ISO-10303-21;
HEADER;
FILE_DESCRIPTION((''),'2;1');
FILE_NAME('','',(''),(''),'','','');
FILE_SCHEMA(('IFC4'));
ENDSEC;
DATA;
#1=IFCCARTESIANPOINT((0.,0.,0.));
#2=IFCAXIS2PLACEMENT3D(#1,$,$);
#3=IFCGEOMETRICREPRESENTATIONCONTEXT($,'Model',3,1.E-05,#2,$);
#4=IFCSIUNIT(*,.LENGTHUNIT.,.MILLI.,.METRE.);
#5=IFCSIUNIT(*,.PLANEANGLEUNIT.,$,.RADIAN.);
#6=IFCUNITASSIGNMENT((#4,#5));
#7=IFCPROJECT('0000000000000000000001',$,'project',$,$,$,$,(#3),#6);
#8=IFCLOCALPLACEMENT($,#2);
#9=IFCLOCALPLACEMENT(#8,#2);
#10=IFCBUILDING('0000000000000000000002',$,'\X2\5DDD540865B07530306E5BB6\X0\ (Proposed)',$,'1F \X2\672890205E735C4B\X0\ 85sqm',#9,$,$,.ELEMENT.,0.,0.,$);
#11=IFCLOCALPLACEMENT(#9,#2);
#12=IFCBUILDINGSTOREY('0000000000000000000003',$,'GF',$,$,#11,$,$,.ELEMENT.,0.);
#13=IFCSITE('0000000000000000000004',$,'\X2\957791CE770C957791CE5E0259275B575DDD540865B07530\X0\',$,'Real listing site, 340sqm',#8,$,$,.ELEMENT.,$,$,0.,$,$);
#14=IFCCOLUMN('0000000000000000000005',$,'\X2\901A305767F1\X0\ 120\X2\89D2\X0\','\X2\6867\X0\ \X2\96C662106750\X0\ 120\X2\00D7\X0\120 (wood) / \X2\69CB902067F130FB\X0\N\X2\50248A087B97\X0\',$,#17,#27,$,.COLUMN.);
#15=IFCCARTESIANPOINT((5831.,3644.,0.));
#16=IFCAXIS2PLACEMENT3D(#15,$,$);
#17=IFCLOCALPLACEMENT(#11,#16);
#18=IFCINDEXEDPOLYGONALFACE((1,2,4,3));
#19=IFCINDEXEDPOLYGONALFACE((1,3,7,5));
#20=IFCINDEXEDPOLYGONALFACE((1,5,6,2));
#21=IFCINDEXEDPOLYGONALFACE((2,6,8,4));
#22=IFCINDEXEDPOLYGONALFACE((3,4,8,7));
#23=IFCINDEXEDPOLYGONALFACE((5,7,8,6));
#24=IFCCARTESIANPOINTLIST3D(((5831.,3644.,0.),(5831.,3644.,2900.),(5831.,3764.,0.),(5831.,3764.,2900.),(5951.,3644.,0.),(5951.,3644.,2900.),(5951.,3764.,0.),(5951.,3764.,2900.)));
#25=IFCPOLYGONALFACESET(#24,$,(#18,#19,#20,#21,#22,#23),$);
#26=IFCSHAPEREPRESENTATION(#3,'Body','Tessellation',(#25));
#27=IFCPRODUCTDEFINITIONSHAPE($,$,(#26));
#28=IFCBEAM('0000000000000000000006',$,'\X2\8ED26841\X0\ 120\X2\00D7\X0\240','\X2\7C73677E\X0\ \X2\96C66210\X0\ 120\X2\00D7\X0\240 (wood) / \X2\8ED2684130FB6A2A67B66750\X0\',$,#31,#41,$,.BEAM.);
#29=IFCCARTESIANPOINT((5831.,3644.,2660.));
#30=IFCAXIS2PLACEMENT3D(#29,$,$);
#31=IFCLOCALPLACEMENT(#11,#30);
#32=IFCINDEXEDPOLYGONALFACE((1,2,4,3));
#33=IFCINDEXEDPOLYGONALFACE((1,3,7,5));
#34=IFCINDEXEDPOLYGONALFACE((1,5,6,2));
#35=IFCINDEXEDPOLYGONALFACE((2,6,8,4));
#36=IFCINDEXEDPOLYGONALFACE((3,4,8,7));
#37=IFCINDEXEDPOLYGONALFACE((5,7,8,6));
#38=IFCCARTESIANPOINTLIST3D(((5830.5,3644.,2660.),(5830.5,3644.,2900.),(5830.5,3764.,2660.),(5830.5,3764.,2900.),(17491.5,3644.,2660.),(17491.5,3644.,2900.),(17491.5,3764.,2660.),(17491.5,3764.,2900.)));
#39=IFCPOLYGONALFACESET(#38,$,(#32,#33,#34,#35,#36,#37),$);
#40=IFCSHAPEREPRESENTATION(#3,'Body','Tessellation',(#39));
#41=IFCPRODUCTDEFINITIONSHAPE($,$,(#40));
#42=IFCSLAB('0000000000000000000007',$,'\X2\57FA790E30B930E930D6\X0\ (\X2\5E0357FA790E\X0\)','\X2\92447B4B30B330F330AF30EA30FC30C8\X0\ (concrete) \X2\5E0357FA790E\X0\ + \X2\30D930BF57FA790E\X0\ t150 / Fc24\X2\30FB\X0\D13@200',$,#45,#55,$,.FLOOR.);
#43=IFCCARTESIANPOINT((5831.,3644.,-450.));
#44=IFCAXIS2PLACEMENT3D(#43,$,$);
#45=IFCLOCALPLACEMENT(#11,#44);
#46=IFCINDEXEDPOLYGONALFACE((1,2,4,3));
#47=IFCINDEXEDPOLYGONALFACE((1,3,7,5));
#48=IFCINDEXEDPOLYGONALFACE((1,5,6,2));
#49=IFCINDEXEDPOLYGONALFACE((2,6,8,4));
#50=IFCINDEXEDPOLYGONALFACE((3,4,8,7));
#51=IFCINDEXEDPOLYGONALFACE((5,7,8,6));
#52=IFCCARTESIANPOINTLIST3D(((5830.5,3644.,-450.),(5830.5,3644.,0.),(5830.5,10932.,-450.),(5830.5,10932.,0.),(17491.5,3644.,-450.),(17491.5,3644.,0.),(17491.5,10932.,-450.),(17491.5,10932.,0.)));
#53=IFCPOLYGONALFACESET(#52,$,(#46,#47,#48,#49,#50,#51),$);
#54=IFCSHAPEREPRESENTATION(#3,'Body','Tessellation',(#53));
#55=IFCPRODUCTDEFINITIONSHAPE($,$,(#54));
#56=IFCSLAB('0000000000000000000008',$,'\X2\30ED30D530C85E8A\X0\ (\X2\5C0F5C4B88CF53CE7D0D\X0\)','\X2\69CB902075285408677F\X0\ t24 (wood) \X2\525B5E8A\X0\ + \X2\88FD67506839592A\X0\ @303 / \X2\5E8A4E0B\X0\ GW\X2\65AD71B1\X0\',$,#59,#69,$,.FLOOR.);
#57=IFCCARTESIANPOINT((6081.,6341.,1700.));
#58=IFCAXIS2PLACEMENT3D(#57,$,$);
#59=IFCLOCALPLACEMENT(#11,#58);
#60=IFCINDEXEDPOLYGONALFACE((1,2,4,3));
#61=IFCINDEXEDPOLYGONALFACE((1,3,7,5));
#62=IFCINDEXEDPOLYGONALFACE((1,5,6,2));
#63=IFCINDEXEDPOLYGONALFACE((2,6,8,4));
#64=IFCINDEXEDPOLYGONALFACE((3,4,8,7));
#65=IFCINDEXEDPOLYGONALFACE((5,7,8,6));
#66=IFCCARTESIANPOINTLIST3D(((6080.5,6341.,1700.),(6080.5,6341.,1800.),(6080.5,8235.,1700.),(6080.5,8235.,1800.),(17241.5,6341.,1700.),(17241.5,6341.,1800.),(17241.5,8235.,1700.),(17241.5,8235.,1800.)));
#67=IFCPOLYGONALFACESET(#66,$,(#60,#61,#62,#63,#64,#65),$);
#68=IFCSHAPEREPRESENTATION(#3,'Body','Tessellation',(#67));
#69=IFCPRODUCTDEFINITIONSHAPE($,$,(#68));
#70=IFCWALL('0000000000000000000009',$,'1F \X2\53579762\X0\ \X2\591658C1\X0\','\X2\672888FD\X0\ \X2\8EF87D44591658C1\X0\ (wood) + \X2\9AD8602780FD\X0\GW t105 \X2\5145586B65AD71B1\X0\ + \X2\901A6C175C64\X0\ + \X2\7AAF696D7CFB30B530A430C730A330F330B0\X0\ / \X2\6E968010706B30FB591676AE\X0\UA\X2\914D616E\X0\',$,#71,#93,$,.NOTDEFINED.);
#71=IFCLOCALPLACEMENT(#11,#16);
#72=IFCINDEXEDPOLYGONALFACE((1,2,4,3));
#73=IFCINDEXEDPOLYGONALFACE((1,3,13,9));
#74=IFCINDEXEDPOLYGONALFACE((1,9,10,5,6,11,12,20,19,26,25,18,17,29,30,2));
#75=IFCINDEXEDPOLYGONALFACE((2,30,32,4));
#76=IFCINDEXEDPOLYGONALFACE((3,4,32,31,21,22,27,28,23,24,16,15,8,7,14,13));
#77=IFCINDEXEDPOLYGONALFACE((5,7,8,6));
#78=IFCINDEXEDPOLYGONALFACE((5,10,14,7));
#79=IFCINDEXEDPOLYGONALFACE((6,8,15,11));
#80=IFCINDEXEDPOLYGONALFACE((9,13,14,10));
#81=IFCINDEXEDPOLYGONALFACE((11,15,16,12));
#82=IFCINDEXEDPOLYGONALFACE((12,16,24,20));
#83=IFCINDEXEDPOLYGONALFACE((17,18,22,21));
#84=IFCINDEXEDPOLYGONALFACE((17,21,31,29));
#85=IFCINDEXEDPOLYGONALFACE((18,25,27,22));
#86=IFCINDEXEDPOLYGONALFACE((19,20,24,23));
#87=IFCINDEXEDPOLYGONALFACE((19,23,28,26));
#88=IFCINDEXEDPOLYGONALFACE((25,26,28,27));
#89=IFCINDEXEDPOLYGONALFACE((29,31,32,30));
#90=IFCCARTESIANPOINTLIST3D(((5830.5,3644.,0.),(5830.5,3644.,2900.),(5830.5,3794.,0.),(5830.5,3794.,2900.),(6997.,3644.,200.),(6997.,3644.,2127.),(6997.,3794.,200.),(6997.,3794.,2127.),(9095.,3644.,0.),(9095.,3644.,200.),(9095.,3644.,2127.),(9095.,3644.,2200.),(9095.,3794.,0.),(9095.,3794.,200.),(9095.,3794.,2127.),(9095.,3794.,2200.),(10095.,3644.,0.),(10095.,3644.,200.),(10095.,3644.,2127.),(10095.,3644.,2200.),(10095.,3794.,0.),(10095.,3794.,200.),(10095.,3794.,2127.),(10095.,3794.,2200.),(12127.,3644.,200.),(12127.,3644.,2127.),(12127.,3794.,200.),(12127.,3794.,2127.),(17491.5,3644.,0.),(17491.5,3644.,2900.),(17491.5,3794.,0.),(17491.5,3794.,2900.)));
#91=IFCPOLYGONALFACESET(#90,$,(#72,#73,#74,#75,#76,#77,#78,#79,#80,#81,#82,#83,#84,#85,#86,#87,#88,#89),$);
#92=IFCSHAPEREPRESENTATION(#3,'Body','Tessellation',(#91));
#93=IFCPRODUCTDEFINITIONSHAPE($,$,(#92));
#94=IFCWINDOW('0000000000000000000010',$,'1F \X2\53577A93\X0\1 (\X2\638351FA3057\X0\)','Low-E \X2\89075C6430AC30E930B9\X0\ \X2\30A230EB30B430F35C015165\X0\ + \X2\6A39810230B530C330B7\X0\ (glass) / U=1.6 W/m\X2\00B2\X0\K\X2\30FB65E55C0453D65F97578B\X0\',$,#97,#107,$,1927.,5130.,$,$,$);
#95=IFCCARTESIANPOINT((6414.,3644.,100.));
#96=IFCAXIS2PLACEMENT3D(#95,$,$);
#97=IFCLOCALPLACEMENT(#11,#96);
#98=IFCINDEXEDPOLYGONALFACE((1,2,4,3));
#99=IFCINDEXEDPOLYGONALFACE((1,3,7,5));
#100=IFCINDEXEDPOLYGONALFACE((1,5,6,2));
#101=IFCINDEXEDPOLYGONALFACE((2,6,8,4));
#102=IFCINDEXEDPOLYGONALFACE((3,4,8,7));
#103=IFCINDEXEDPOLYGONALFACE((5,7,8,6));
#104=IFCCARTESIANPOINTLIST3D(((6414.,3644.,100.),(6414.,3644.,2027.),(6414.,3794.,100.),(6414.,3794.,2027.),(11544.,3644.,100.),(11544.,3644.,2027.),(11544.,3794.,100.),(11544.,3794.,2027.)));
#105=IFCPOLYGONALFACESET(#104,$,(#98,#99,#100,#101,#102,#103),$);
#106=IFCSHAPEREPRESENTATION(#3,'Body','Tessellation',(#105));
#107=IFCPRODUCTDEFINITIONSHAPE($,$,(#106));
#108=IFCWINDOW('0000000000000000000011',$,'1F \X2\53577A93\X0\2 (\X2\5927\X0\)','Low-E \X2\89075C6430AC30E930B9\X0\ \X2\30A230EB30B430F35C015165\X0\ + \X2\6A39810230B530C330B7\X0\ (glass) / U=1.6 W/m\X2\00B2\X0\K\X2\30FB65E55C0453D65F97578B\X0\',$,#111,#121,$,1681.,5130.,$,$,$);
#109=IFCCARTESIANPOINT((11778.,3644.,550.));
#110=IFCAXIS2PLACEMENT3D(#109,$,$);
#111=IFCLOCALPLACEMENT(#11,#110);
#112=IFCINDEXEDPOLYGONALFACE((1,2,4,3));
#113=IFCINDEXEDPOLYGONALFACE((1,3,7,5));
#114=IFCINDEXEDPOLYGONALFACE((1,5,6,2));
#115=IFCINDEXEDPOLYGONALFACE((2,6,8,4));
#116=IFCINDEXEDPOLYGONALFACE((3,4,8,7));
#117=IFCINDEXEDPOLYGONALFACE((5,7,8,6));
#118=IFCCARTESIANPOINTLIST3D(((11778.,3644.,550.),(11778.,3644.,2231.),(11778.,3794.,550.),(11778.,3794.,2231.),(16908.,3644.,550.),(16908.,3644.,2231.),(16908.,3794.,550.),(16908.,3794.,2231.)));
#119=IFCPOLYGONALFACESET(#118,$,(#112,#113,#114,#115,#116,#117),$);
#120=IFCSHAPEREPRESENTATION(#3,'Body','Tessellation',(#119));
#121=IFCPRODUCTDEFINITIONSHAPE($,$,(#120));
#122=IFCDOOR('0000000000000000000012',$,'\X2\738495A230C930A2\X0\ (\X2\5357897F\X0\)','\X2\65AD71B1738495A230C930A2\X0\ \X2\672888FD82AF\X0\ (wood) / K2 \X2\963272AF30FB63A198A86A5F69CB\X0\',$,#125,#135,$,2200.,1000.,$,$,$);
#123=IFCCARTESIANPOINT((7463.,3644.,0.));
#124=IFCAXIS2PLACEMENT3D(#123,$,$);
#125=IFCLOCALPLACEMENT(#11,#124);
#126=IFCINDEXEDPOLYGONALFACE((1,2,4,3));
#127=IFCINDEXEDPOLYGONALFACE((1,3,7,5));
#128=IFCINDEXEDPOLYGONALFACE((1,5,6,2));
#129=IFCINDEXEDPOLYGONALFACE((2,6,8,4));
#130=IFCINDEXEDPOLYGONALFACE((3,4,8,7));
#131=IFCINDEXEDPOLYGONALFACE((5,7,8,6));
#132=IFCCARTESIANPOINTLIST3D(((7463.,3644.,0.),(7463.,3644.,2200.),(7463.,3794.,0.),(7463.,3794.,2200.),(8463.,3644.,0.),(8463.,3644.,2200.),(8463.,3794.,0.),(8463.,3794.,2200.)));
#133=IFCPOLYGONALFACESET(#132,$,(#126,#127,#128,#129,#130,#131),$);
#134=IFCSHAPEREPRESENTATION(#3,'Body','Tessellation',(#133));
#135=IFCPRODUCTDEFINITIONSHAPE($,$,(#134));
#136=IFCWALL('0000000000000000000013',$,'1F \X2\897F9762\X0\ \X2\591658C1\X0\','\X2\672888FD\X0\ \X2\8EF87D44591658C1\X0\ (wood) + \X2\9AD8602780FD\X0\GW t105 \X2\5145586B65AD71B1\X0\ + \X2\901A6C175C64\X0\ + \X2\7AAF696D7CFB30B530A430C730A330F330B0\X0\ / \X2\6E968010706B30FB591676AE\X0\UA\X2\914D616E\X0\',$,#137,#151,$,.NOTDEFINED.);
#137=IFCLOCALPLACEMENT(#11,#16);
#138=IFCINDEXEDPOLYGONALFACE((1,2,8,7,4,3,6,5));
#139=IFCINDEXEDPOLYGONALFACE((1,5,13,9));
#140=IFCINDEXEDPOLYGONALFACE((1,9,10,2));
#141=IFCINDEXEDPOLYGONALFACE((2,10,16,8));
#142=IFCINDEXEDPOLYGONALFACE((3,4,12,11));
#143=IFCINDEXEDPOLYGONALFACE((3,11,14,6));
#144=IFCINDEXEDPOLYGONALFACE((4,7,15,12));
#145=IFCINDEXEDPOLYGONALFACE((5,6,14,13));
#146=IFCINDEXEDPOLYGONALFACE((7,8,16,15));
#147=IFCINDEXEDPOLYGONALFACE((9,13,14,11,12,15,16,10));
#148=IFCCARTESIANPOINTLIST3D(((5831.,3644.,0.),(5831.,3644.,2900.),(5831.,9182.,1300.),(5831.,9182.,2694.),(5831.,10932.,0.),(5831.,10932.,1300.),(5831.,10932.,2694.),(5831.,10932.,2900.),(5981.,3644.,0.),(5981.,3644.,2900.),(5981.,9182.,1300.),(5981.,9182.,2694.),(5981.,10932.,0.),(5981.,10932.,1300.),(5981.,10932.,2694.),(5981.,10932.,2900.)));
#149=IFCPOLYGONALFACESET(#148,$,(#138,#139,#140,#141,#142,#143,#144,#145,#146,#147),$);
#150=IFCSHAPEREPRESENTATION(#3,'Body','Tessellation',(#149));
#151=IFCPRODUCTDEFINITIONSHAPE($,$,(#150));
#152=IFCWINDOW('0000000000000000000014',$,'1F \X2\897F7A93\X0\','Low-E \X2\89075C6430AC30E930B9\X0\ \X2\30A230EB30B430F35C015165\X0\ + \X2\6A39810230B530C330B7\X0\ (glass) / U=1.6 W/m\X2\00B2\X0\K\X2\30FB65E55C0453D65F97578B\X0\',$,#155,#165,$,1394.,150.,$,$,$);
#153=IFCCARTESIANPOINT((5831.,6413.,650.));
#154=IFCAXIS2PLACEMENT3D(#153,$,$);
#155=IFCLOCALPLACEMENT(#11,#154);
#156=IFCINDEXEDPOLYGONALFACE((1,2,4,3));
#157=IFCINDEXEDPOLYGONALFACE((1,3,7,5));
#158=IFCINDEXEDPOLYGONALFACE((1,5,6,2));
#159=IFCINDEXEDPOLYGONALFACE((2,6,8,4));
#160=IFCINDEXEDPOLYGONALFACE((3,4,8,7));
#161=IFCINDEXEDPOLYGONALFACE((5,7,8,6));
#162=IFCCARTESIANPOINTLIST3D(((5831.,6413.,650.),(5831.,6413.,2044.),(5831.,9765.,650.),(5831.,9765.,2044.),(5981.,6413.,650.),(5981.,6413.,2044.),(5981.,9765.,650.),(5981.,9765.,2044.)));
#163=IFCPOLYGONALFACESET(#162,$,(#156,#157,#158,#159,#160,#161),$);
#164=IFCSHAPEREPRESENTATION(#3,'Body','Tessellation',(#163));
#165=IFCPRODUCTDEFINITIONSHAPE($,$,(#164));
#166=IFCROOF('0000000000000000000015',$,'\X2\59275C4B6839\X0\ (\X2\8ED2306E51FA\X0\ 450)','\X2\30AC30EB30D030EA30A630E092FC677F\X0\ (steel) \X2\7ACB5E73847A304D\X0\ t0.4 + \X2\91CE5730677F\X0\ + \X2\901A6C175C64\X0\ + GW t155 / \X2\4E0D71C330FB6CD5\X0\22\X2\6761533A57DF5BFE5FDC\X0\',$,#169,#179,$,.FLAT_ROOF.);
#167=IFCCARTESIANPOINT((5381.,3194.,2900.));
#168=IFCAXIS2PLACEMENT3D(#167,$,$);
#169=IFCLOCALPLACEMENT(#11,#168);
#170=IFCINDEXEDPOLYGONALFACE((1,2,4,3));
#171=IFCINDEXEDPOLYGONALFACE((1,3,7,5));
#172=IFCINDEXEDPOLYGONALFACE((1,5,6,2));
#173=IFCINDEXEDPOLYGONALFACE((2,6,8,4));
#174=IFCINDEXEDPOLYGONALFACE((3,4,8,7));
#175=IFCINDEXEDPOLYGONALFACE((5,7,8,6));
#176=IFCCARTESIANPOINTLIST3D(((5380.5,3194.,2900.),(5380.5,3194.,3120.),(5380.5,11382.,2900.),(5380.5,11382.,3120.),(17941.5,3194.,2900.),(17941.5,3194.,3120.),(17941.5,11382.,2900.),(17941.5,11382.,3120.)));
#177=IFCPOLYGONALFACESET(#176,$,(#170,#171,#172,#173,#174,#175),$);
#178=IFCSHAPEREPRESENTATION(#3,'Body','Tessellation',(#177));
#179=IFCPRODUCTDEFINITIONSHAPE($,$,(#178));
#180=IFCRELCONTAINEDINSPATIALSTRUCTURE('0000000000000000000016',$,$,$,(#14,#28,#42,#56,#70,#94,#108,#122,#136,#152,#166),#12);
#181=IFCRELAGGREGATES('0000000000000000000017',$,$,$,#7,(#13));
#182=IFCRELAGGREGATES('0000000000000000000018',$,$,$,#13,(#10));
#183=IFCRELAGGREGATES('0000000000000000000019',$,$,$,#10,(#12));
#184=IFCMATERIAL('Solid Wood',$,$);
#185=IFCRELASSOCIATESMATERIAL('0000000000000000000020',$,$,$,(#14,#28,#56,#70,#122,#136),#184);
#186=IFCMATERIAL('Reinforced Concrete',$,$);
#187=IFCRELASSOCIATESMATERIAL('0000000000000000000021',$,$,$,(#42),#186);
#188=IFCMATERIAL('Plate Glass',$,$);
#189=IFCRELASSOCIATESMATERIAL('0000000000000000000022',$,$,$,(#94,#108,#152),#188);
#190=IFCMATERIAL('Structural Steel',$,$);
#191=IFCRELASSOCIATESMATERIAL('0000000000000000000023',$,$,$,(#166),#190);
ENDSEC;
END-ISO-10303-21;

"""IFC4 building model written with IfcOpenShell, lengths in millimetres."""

from ifc_helpers import new_model, si_unit, frame, frame_2d, origin, place, context, project, spatial, rectangle, extrude, material, element, fill, save


model = new_model("IFC4")

# Units and contexts
model_context = context("Model", 3, precision=1e-05, world=origin())
ifc_project = project(units=[si_unit("LENGTHUNIT", "METRE", prefix="MILLI"), si_unit("PLANEANGLEUNIT", "RADIAN")], contexts=[model_context])

# Site, building, storey
site_placement = place(None, origin())
site = spatial("IfcSite", under=ifc_project, at=site_placement, Name="長野県長野市大字川合新田", ObjectType="Real listing site, 340sqm", CompositionType="ELEMENT", RefElevation=0.0)
building_placement = place(site_placement, origin())
building = spatial("IfcBuilding", under=site, at=building_placement, Name="川合新田の家 (Proposed)", ObjectType="1F 木造平屋 85sqm", CompositionType="ELEMENT", ElevationOfRefHeight=0.0, ElevationOfTerrain=0.0)
storey_placement = place(building_placement, origin())
storey = spatial("IfcBuildingStorey", under=building, at=storey_placement, Name="GF", CompositionType="ELEMENT", Elevation=0.0)

# Column
ifc_material_1 = material(Name="Solid Wood")
column_1_placement = place(storey_placement, frame((5831.0, 3644.0, 0.0)))
element("IfcColumn", 1, at=column_1_placement, inside=storey, material=ifc_material_1, Name="通し柱 120角", Description="桧 集成材 120×120 (wood) / 構造柱・N値計算", PredefinedType="COLUMN", context=model_context, shape_type="SweptSolid", body=[
    extrude(rectangle(XDim=120.0, YDim=120.0, at=frame_2d((60.0, 60.0))), frame((5831.0, 3644.0, 0.0)), (0.0, 0.0, 1.0), 2900.0),
])

# Beam
beam_1_placement = place(storey_placement, frame((5831.0, 3644.0, 2660.0)))
element("IfcBeam", 2, at=beam_1_placement, inside=storey, material=ifc_material_1, Name="軒桁 120×240", Description="米松 集成 120×240 (wood) / 軒桁・横架材", PredefinedType="BEAM", context=model_context, shape_type="SweptSolid", body=[
    extrude(rectangle(XDim=11661.0, YDim=120.0, at=frame_2d((5830.0, 60.0))), frame((5831.0, 3644.0, 2660.0)), (0.0, 0.0, 1.0), 240.0),
])

# Slabs
ifc_material_2 = material(Name="Reinforced Concrete")
slab_1_placement = place(storey_placement, frame((5831.0, 3644.0, -450.0)))
element("IfcSlab", 3, at=slab_1_placement, inside=storey, material=ifc_material_2, Name="基礎スラブ (布基礎)", Description="鉄筋コンクリート (concrete) 布基礎 + ベタ基礎 t150 / Fc24・D13@200", PredefinedType="FLOOR", context=model_context, shape_type="SweptSolid", body=[
    extrude(rectangle(XDim=11661.0, YDim=7288.0, at=frame_2d((5830.0, 3644.0))), frame((5831.0, 3644.0, -450.0)), (0.0, 0.0, 1.0), 450.0),
])
slab_2_placement = place(storey_placement, frame((6081.0, 6341.0, 1700.0)))
element("IfcSlab", 4, at=slab_2_placement, inside=storey, material=ifc_material_1, Name="ロフト床 (小屋裏収納)", Description="構造用合板 t24 (wood) 剛床 + 製材根太 @303 / 床下 GW断熱", PredefinedType="FLOOR", context=model_context, shape_type="SweptSolid", body=[
    extrude(rectangle(XDim=11161.0, YDim=1894.0, at=frame_2d((5580.0, 947.0))), frame((6081.0, 6341.0, 1700.0)), (0.0, 0.0, 1.0), 100.0),
])

# Wall, openings, windows, door
wall_1_placement = place(storey_placement, frame((5831.0, 3644.0, 0.0)))
wall_1 = element("IfcWall", 5, at=wall_1_placement, inside=storey, material=ifc_material_1, Name="1F 南面 外壁", Description="木製 軸組外壁 (wood) + 高性能GW t105 充填断熱 + 通気層 + 窯業系サイディング / 準耐火・外皮UA配慮", PredefinedType="NOTDEFINED", context=model_context, shape_type="SweptSolid", body=[
    extrude(rectangle(XDim=11661.0, YDim=150.0, at=frame_2d((5830.0, 75.0))), frame((5831.0, 3644.0, 0.0)), (0.0, 0.0, 1.0), 2900.0),
])
opening_1_placement = place(storey_placement, frame((6414.0, 3644.0, 100.0)))
opening_1 = element("IfcOpeningElement", 6, at=opening_1_placement, cuts=wall_1, PredefinedType="NOTDEFINED", context=model_context, shape_type="SweptSolid", body=[
    extrude(rectangle(XDim=5130.0, YDim=150.0, at=frame_2d((2565.0, 75.0))), frame((6414.0, 3644.0, 100.0)), (0.0, 0.0, 1.0), 1927.0),
])
opening_2_placement = place(storey_placement, frame((11778.0, 3644.0, 550.0)))
opening_2 = element("IfcOpeningElement", 7, at=opening_2_placement, cuts=wall_1, PredefinedType="NOTDEFINED", context=model_context, shape_type="SweptSolid", body=[
    extrude(rectangle(XDim=5130.0, YDim=150.0, at=frame_2d((2565.0, 75.0))), frame((11778.0, 3644.0, 550.0)), (0.0, 0.0, 1.0), 1681.0),
])
opening_3_placement = place(storey_placement, frame((7463.0, 3644.0, 0.0)))
opening_3 = element("IfcOpeningElement", 8, at=opening_3_placement, cuts=wall_1, PredefinedType="NOTDEFINED", context=model_context, shape_type="SweptSolid", body=[
    extrude(rectangle(XDim=1000.0, YDim=150.0, at=frame_2d((500.0, 75.0))), frame((7463.0, 3644.0, 0.0)), (0.0, 0.0, 1.0), 2200.0),
])
ifc_material_3 = material(Name="Plate Glass")
window_1_placement = place(storey_placement, frame((6414.0, 3644.0, 100.0)))
window_1 = element("IfcWindow", 9, at=window_1_placement, inside=storey, material=ifc_material_3, Name="1F 南窓1 (掃出し)", Description="Low-E 複層ガラス アルゴン封入 + 樹脂サッシ (glass) / U=1.6 W/m²K・日射取得型", OverallHeight=1927.0, OverallWidth=5130.0, context=model_context, shape_type="SweptSolid", body=[
    extrude(rectangle(XDim=5130.0, YDim=150.0, at=frame_2d((2565.0, 75.0))), frame((6414.0, 3644.0, 100.0)), (0.0, 0.0, 1.0), 1927.0),
])
fill(opening_1, window_1)
window_2_placement = place(storey_placement, frame((11778.0, 3644.0, 550.0)))
window_2 = element("IfcWindow", 10, at=window_2_placement, inside=storey, material=ifc_material_3, Name="1F 南窓2 (大)", Description="Low-E 複層ガラス アルゴン封入 + 樹脂サッシ (glass) / U=1.6 W/m²K・日射取得型", OverallHeight=1681.0, OverallWidth=5130.0, context=model_context, shape_type="SweptSolid", body=[
    extrude(rectangle(XDim=5130.0, YDim=150.0, at=frame_2d((2565.0, 75.0))), frame((11778.0, 3644.0, 550.0)), (0.0, 0.0, 1.0), 1681.0),
])
fill(opening_2, window_2)
door_placement = place(storey_placement, frame((7463.0, 3644.0, 0.0)))
door = element("IfcDoor", 11, at=door_placement, inside=storey, material=ifc_material_1, Name="玄関ドア (南西)", Description="断熱玄関ドア 木製芯 (wood) / K2 防犯・採風機構", OverallHeight=2200.0, OverallWidth=1000.0, context=model_context, shape_type="SweptSolid", body=[
    extrude(rectangle(XDim=1000.0, YDim=150.0, at=frame_2d((500.0, 75.0))), frame((7463.0, 3644.0, 0.0)), (0.0, 0.0, 1.0), 2200.0),
])
fill(opening_3, door)

# Wall, opening, window
wall_2_placement = place(storey_placement, frame((5831.0, 3644.0, 0.0)))
wall_2 = element("IfcWall", 12, at=wall_2_placement, inside=storey, material=ifc_material_1, Name="1F 西面 外壁", Description="木製 軸組外壁 (wood) + 高性能GW t105 充填断熱 + 通気層 + 窯業系サイディング / 準耐火・外皮UA配慮", PredefinedType="NOTDEFINED", context=model_context, shape_type="SweptSolid", body=[
    extrude(rectangle(XDim=150.0, YDim=7288.0, at=frame_2d((75.0, 3644.0))), frame((5831.0, 3644.0, 0.0)), (0.0, 0.0, 1.0), 2900.0),
])
opening_4_placement = place(storey_placement, frame((5831.0, 6413.0, 650.0)))
opening_4 = element("IfcOpeningElement", 13, at=opening_4_placement, cuts=wall_2, PredefinedType="NOTDEFINED", context=model_context, shape_type="SweptSolid", body=[
    extrude(rectangle(XDim=150.0, YDim=3352.0, at=frame_2d((75.0, 1676.0))), frame((5831.0, 6413.0, 650.0)), (0.0, 0.0, 1.0), 1394.0),
])
window_3_placement = place(storey_placement, frame((5831.0, 6413.0, 650.0)))
window_3 = element("IfcWindow", 14, at=window_3_placement, inside=storey, material=ifc_material_3, Name="1F 西窓", Description="Low-E 複層ガラス アルゴン封入 + 樹脂サッシ (glass) / U=1.6 W/m²K・日射取得型", OverallHeight=1394.0, OverallWidth=150.0, context=model_context, shape_type="SweptSolid", body=[
    extrude(rectangle(XDim=150.0, YDim=3352.0, at=frame_2d((75.0, 1676.0))), frame((5831.0, 6413.0, 650.0)), (0.0, 0.0, 1.0), 1394.0),
])
fill(opening_4, window_3)

# Roof
ifc_material_4 = material(Name="Structural Steel")
roof_placement = place(storey_placement, frame((5381.0, 3194.0, 2900.0)))
element("IfcRoof", 15, at=roof_placement, inside=storey, material=ifc_material_4, Name="大屋根 (軒の出 450)", Description="ガルバリウム鋼板 (steel) 立平葺き t0.4 + 野地板 + 通気層 + GW t155 / 不燃・法22条区域対応", PredefinedType="FLAT_ROOF", context=model_context, shape_type="SweptSolid", body=[
    extrude(rectangle(XDim=12561.0, YDim=8188.0, at=frame_2d((6280.0, 4094.0))), frame((5381.0, 3194.0, 2900.0)), (0.0, 0.0, 1.0), 220.0),
])

save(model, "model.ifc")
